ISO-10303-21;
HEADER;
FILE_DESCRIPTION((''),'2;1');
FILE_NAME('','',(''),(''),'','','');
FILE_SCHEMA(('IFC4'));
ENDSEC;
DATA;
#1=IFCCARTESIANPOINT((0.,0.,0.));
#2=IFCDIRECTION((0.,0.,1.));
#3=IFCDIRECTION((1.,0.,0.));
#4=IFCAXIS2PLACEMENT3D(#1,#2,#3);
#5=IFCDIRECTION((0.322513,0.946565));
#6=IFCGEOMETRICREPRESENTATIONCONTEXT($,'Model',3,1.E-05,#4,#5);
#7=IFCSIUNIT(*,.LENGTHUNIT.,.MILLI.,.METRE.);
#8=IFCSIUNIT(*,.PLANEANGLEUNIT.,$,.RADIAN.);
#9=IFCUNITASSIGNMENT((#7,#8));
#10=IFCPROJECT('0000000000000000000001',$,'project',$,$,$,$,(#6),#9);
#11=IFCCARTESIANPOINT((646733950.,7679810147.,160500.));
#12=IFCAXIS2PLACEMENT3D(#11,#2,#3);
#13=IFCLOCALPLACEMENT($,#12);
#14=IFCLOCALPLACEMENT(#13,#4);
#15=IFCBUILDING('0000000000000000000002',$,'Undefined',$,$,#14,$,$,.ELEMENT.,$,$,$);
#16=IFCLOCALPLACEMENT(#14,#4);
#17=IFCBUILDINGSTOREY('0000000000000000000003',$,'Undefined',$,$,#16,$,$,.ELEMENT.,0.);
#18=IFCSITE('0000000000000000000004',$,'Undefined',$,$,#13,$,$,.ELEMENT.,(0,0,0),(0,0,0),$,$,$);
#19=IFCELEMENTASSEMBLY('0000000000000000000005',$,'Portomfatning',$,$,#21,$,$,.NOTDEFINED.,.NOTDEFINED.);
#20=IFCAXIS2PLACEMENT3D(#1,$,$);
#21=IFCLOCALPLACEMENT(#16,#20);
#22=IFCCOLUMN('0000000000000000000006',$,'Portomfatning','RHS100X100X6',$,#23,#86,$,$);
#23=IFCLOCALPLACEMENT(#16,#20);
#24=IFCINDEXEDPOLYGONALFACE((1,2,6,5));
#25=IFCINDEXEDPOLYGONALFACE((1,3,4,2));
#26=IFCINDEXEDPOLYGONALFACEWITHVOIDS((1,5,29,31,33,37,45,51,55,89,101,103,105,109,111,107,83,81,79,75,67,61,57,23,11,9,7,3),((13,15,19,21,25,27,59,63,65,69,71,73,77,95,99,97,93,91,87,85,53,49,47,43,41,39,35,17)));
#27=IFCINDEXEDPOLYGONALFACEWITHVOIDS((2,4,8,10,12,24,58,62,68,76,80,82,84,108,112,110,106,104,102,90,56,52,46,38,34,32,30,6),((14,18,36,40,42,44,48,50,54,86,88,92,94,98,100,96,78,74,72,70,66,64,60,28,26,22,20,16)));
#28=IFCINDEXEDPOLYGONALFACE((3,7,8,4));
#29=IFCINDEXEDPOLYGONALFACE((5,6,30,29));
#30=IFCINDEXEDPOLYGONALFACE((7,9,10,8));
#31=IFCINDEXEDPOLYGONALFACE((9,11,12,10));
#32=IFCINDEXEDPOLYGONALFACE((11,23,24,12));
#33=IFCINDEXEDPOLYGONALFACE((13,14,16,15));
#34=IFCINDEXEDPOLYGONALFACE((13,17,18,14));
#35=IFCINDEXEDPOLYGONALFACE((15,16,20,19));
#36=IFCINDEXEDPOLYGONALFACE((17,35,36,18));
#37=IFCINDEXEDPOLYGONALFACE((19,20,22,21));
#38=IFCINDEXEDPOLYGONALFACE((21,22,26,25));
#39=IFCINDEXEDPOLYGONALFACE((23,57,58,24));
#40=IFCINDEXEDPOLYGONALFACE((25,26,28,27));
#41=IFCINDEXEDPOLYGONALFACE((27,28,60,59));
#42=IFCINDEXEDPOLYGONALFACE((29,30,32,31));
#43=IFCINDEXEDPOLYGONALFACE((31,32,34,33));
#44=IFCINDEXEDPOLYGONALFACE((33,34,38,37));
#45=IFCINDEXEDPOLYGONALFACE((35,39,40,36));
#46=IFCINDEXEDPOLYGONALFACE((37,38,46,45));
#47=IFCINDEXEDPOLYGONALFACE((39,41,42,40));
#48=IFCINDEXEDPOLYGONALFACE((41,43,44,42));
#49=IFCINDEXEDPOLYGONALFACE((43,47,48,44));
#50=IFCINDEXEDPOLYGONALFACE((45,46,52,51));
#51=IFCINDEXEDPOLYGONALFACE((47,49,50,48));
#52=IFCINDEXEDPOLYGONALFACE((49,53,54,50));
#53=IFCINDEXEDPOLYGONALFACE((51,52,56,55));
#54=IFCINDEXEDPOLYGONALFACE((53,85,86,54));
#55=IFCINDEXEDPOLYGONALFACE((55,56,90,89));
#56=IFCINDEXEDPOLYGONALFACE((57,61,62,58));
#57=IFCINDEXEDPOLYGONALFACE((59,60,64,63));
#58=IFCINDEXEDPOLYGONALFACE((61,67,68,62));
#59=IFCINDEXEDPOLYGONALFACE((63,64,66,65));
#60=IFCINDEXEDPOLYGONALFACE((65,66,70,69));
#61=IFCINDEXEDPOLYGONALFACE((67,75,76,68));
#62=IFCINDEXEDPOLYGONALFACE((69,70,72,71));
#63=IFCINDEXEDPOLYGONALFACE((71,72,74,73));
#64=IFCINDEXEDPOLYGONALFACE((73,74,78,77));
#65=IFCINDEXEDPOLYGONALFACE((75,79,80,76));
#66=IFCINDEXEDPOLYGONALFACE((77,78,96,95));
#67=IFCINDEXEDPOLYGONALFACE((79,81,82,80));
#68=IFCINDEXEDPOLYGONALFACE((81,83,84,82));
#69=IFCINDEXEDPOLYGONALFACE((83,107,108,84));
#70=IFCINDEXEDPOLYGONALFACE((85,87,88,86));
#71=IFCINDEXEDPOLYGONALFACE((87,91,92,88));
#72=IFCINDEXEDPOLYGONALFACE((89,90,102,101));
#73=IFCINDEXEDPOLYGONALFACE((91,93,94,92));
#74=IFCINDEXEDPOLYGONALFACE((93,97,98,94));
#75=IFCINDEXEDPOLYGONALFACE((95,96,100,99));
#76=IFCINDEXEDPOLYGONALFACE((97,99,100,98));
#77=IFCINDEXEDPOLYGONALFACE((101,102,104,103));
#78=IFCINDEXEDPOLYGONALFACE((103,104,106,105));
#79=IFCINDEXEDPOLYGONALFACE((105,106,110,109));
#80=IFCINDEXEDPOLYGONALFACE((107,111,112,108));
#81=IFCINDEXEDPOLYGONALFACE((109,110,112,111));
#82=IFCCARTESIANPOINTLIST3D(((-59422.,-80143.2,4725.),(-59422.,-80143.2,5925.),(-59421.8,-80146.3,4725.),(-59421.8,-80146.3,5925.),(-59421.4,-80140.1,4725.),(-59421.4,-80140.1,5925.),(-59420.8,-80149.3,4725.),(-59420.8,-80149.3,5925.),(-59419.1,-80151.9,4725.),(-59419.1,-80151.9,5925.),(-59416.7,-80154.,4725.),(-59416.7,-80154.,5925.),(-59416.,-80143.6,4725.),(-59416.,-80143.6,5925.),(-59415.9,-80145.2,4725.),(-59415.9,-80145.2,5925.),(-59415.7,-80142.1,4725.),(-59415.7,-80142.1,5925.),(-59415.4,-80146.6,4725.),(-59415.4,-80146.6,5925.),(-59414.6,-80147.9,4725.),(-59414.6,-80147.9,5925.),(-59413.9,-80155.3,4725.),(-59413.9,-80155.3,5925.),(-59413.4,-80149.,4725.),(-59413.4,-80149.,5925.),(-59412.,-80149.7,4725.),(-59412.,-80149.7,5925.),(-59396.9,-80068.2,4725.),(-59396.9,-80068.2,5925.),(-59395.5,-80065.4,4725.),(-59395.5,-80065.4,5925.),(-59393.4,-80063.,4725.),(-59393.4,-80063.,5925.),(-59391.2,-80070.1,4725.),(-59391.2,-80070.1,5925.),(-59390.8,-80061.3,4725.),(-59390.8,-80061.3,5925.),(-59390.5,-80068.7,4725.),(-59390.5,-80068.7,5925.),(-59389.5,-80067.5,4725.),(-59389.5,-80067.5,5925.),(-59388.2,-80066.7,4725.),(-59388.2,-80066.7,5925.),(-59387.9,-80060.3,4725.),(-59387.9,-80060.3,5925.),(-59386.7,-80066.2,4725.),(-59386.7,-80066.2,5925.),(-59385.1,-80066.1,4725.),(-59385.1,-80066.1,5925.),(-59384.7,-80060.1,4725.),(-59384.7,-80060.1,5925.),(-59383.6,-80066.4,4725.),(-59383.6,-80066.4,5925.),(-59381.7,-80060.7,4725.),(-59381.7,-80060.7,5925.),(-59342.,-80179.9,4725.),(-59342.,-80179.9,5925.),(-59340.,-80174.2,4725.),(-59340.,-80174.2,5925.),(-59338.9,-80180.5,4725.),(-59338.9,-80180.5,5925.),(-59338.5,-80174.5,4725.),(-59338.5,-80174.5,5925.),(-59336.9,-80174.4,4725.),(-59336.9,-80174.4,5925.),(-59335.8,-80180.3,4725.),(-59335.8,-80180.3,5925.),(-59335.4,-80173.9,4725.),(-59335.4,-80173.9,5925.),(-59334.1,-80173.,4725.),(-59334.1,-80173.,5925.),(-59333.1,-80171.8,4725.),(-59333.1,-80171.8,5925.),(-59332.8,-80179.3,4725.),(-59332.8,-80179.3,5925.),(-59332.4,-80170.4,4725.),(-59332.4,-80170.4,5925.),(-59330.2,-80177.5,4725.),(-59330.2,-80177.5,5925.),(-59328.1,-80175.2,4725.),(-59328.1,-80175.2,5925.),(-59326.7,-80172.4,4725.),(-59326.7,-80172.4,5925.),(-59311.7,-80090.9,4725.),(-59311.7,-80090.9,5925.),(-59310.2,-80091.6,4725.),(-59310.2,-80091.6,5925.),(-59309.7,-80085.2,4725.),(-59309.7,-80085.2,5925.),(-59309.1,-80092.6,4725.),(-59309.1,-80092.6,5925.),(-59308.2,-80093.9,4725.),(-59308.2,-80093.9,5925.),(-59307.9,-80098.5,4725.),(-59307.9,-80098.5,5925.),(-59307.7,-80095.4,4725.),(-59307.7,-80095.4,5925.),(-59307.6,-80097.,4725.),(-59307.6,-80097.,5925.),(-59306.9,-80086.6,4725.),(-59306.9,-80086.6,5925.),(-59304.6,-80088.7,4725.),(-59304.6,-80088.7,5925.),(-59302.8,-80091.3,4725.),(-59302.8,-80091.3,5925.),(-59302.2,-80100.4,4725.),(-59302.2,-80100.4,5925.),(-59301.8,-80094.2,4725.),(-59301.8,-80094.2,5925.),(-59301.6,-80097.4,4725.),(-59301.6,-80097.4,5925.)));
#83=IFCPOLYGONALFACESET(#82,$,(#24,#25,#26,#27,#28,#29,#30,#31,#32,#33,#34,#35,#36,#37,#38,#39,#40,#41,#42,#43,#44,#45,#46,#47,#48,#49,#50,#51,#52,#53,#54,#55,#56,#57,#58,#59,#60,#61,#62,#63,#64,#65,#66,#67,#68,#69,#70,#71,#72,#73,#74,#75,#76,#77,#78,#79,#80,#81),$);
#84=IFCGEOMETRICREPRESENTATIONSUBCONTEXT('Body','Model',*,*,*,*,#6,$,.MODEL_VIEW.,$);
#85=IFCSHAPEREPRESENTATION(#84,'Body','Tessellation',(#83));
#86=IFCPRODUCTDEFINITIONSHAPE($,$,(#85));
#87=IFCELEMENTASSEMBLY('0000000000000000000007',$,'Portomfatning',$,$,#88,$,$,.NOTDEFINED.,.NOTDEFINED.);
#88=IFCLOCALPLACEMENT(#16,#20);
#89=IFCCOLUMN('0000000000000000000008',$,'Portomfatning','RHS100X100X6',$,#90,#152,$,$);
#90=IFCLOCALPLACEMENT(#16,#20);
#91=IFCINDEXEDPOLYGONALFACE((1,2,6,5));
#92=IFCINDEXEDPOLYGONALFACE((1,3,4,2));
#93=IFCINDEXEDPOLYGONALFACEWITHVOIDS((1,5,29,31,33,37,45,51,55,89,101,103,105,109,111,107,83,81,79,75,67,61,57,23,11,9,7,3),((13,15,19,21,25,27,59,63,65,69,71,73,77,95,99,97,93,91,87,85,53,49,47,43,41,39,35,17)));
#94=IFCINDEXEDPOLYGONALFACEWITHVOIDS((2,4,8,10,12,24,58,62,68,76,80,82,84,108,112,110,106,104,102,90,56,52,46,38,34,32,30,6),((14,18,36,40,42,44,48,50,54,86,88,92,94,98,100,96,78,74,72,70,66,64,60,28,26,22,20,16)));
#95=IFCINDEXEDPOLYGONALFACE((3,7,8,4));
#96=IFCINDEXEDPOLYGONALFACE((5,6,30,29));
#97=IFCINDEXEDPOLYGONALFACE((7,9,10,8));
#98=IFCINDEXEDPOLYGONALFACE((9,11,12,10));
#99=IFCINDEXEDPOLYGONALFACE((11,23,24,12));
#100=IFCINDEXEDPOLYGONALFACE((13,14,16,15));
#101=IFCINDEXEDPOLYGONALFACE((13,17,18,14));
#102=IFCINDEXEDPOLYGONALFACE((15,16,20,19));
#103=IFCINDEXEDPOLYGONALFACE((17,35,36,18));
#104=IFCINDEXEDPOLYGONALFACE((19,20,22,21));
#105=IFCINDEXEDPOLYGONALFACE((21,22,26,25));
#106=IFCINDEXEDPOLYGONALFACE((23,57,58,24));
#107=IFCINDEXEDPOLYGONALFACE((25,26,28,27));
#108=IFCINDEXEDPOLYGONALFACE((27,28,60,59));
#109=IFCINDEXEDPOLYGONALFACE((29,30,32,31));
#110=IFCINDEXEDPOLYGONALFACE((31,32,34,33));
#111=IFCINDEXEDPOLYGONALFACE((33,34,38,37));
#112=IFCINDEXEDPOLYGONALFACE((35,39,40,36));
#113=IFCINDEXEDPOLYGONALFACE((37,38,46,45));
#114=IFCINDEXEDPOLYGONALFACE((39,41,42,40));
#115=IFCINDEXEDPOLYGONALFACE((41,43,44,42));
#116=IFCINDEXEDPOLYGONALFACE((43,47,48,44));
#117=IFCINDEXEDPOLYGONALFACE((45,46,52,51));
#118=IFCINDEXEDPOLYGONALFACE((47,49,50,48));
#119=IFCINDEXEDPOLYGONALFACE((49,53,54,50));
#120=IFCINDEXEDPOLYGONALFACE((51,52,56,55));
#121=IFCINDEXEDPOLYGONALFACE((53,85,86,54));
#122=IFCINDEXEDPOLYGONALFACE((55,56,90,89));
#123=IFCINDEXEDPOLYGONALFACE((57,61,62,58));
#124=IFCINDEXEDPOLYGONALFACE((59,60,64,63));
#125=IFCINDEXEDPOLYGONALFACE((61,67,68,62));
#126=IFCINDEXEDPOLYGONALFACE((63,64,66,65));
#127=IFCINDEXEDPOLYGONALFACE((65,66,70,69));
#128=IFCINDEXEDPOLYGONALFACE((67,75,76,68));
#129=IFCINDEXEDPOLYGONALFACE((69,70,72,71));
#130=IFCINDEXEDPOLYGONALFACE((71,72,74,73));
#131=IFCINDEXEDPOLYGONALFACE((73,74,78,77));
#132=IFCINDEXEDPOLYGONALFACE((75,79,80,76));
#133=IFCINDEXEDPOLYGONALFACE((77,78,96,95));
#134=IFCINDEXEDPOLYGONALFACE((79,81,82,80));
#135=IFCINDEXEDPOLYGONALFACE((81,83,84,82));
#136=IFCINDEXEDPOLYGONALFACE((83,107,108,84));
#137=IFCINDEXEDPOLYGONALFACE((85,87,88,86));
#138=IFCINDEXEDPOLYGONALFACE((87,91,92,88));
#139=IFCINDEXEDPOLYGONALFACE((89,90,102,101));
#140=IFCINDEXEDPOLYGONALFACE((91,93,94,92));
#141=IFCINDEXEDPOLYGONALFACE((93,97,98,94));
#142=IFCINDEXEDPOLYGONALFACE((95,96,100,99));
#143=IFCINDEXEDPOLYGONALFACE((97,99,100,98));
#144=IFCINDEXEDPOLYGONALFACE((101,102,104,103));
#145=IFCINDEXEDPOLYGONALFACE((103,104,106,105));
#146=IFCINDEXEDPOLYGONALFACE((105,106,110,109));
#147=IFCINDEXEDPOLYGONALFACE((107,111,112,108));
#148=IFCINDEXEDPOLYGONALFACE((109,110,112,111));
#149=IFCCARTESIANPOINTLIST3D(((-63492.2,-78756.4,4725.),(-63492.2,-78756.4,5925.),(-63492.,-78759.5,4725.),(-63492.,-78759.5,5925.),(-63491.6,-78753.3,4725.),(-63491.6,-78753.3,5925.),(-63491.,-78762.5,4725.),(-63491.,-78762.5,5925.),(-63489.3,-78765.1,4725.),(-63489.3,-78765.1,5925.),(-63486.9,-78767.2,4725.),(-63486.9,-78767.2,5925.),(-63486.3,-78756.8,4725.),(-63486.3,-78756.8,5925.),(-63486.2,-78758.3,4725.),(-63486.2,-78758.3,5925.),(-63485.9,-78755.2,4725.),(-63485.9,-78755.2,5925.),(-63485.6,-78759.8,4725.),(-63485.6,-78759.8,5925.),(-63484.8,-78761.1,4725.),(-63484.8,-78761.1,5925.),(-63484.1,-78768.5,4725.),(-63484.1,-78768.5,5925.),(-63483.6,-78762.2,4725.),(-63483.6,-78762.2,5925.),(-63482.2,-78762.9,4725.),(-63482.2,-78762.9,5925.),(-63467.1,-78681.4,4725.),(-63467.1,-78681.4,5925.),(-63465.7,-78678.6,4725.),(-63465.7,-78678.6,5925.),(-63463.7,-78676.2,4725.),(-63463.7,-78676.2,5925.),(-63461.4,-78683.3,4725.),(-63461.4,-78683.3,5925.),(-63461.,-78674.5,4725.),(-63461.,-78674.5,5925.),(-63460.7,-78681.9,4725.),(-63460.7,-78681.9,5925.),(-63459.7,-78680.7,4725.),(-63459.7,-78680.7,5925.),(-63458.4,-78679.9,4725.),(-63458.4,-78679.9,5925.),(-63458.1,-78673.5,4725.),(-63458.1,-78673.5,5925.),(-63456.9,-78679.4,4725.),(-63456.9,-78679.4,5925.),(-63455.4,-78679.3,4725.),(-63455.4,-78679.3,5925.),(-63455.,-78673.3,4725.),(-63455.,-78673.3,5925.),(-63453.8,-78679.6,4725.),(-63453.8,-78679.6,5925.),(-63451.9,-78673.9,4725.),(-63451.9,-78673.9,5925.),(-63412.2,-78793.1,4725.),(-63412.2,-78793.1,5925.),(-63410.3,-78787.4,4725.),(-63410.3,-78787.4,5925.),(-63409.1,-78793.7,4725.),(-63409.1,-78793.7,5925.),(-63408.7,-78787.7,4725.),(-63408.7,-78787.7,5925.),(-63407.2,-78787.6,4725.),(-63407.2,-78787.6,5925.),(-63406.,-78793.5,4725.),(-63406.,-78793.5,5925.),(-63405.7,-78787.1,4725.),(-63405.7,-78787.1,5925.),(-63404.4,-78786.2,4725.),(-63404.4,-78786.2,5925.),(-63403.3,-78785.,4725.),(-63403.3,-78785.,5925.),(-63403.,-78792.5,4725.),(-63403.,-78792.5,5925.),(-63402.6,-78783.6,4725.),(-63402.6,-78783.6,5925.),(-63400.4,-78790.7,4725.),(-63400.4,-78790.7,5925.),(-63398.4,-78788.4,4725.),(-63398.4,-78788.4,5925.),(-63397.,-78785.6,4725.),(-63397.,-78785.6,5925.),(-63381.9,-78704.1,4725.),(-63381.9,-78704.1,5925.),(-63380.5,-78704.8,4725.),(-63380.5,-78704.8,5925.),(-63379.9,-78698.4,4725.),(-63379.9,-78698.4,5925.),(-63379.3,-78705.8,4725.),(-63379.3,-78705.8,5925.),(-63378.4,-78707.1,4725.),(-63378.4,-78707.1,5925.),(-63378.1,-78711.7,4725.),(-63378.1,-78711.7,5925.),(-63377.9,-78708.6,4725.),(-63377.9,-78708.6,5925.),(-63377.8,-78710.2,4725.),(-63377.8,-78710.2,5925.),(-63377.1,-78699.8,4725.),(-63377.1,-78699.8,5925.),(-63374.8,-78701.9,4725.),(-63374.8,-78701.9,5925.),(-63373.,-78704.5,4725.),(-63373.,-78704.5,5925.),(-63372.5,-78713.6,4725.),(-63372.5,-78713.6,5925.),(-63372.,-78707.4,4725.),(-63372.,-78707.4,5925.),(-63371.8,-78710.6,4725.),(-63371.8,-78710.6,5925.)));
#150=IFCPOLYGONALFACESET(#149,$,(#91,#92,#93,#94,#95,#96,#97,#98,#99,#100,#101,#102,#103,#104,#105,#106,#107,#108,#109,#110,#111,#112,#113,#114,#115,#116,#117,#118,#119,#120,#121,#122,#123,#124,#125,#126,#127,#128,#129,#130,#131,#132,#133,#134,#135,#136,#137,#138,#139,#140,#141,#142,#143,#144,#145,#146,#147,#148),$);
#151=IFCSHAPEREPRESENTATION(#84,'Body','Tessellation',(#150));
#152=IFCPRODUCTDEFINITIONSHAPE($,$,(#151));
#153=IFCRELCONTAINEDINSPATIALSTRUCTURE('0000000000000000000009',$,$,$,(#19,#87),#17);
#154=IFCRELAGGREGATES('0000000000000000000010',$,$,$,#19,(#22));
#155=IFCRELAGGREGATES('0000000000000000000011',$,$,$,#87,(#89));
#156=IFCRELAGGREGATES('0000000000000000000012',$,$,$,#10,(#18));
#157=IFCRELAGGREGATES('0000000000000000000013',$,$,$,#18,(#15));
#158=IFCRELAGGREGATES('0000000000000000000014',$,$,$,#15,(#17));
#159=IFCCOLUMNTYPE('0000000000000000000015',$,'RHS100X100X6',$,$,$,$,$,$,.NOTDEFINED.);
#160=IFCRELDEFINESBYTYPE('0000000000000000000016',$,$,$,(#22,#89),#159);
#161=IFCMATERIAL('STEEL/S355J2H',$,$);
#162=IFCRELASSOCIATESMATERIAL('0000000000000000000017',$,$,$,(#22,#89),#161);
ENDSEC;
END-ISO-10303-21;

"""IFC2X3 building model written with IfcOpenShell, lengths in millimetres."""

from ifc_helpers import new_model, si_unit, direction, frame, origin_with_axes, origin_2d_with_axis, place, context, subcontext, project, spatial, hollow_rectangle, extrude, material, type_object, element, aggregate, save


model = new_model("IFC2X3")

# Units and contexts
model_context = context("Model", 3, precision=1e-05, world=origin_with_axes(), true_north=direction((0.322513, 0.946565)))
body_context = subcontext(model_context, "Body", "Model", "MODEL_VIEW")
ifc_project = project(units=[si_unit("LENGTHUNIT", "METRE", prefix="MILLI"), si_unit("PLANEANGLEUNIT", "RADIAN")], contexts=[model_context])

# Site, building, storey
site_placement = place(None, frame((646733950.0, 7679810147.0, 160500.0), z_axis=(0.0, 0.0, 1.0), x_axis=(1.0, 0.0, 0.0)))
site = spatial("IfcSite", under=ifc_project, at=site_placement, Name="Undefined", CompositionType="ELEMENT", RefLatitude=(0, 0, 0), RefLongitude=(0, 0, 0))
building_placement = place(site_placement, origin_with_axes())
building = spatial("IfcBuilding", under=site, at=building_placement, Name="Undefined", CompositionType="ELEMENT")
storey_placement = place(building_placement, origin_with_axes())
storey = spatial("IfcBuildingStorey", under=building, at=storey_placement, Name="Undefined", CompositionType="ELEMENT", Elevation=0.0)

# Element assemblies, columns
assembly_1_placement = place(storey_placement, origin_with_axes())
assembly_1 = element("IfcElementAssembly", 1, at=assembly_1_placement, inside=storey, Name="Portomfatning", AssemblyPlace="NOTDEFINED", PredefinedType="NOTDEFINED")
ifc_material_1 = material(Name="STEEL/S355J2H")
column_type_1 = type_object("IfcColumnType", Name="RHS100X100X6", PredefinedType="NOTDEFINED")
column_1_placement = place(assembly_1_placement, frame((-59361.8, -80120.3, 4725.0), z_axis=(0.0, 0.0, 1.0), x_axis=(-0.946565, 0.322513, 0.0)))
column_1 = element("IfcColumn", 2, at=column_1_placement, type_object=column_type_1, material=ifc_material_1, Name="Portomfatning", Description="RHS100X100X6", context=body_context, shape_type="SweptSolid", body=[
    extrude(hollow_rectangle(XDim=100.0, YDim=100.0, WallThickness=6.0, InnerFilletRadius=6.0, OuterFilletRadius=12.0, at=origin_2d_with_axis()), frame((0.0, 0.0, 1200.0), z_axis=(0.0, 0.0, -1.0), x_axis=(0.0, 1.0, 0.0)), (0.0, 0.0, 1.0), 1200.0),
])
aggregate(assembly_1, [column_1])
assembly_2_placement = place(storey_placement, origin_with_axes())
assembly_2 = element("IfcElementAssembly", 3, at=assembly_2_placement, inside=storey, Name="Portomfatning", AssemblyPlace="NOTDEFINED", PredefinedType="NOTDEFINED")
column_2_placement = place(assembly_2_placement, frame((-63432.0, -78733.5, 4725.0), z_axis=(0.0, 0.0, 1.0), x_axis=(-0.946565, 0.322513, 0.0)))
column_2 = element("IfcColumn", 4, at=column_2_placement, type_object=column_type_1, material=ifc_material_1, Name="Portomfatning", Description="RHS100X100X6", context=body_context, shape_type="SweptSolid", body=[
    extrude(hollow_rectangle(XDim=100.0, YDim=100.0, WallThickness=6.0, InnerFilletRadius=6.0, OuterFilletRadius=12.0, at=origin_2d_with_axis()), frame((0.0, 0.0, 1200.0), z_axis=(0.0, 0.0, -1.0), x_axis=(0.0, 1.0, 0.0)), (0.0, 0.0, 1.0), 1200.0),
])
aggregate(assembly_2, [column_2])

save(model, "model.ifc")
